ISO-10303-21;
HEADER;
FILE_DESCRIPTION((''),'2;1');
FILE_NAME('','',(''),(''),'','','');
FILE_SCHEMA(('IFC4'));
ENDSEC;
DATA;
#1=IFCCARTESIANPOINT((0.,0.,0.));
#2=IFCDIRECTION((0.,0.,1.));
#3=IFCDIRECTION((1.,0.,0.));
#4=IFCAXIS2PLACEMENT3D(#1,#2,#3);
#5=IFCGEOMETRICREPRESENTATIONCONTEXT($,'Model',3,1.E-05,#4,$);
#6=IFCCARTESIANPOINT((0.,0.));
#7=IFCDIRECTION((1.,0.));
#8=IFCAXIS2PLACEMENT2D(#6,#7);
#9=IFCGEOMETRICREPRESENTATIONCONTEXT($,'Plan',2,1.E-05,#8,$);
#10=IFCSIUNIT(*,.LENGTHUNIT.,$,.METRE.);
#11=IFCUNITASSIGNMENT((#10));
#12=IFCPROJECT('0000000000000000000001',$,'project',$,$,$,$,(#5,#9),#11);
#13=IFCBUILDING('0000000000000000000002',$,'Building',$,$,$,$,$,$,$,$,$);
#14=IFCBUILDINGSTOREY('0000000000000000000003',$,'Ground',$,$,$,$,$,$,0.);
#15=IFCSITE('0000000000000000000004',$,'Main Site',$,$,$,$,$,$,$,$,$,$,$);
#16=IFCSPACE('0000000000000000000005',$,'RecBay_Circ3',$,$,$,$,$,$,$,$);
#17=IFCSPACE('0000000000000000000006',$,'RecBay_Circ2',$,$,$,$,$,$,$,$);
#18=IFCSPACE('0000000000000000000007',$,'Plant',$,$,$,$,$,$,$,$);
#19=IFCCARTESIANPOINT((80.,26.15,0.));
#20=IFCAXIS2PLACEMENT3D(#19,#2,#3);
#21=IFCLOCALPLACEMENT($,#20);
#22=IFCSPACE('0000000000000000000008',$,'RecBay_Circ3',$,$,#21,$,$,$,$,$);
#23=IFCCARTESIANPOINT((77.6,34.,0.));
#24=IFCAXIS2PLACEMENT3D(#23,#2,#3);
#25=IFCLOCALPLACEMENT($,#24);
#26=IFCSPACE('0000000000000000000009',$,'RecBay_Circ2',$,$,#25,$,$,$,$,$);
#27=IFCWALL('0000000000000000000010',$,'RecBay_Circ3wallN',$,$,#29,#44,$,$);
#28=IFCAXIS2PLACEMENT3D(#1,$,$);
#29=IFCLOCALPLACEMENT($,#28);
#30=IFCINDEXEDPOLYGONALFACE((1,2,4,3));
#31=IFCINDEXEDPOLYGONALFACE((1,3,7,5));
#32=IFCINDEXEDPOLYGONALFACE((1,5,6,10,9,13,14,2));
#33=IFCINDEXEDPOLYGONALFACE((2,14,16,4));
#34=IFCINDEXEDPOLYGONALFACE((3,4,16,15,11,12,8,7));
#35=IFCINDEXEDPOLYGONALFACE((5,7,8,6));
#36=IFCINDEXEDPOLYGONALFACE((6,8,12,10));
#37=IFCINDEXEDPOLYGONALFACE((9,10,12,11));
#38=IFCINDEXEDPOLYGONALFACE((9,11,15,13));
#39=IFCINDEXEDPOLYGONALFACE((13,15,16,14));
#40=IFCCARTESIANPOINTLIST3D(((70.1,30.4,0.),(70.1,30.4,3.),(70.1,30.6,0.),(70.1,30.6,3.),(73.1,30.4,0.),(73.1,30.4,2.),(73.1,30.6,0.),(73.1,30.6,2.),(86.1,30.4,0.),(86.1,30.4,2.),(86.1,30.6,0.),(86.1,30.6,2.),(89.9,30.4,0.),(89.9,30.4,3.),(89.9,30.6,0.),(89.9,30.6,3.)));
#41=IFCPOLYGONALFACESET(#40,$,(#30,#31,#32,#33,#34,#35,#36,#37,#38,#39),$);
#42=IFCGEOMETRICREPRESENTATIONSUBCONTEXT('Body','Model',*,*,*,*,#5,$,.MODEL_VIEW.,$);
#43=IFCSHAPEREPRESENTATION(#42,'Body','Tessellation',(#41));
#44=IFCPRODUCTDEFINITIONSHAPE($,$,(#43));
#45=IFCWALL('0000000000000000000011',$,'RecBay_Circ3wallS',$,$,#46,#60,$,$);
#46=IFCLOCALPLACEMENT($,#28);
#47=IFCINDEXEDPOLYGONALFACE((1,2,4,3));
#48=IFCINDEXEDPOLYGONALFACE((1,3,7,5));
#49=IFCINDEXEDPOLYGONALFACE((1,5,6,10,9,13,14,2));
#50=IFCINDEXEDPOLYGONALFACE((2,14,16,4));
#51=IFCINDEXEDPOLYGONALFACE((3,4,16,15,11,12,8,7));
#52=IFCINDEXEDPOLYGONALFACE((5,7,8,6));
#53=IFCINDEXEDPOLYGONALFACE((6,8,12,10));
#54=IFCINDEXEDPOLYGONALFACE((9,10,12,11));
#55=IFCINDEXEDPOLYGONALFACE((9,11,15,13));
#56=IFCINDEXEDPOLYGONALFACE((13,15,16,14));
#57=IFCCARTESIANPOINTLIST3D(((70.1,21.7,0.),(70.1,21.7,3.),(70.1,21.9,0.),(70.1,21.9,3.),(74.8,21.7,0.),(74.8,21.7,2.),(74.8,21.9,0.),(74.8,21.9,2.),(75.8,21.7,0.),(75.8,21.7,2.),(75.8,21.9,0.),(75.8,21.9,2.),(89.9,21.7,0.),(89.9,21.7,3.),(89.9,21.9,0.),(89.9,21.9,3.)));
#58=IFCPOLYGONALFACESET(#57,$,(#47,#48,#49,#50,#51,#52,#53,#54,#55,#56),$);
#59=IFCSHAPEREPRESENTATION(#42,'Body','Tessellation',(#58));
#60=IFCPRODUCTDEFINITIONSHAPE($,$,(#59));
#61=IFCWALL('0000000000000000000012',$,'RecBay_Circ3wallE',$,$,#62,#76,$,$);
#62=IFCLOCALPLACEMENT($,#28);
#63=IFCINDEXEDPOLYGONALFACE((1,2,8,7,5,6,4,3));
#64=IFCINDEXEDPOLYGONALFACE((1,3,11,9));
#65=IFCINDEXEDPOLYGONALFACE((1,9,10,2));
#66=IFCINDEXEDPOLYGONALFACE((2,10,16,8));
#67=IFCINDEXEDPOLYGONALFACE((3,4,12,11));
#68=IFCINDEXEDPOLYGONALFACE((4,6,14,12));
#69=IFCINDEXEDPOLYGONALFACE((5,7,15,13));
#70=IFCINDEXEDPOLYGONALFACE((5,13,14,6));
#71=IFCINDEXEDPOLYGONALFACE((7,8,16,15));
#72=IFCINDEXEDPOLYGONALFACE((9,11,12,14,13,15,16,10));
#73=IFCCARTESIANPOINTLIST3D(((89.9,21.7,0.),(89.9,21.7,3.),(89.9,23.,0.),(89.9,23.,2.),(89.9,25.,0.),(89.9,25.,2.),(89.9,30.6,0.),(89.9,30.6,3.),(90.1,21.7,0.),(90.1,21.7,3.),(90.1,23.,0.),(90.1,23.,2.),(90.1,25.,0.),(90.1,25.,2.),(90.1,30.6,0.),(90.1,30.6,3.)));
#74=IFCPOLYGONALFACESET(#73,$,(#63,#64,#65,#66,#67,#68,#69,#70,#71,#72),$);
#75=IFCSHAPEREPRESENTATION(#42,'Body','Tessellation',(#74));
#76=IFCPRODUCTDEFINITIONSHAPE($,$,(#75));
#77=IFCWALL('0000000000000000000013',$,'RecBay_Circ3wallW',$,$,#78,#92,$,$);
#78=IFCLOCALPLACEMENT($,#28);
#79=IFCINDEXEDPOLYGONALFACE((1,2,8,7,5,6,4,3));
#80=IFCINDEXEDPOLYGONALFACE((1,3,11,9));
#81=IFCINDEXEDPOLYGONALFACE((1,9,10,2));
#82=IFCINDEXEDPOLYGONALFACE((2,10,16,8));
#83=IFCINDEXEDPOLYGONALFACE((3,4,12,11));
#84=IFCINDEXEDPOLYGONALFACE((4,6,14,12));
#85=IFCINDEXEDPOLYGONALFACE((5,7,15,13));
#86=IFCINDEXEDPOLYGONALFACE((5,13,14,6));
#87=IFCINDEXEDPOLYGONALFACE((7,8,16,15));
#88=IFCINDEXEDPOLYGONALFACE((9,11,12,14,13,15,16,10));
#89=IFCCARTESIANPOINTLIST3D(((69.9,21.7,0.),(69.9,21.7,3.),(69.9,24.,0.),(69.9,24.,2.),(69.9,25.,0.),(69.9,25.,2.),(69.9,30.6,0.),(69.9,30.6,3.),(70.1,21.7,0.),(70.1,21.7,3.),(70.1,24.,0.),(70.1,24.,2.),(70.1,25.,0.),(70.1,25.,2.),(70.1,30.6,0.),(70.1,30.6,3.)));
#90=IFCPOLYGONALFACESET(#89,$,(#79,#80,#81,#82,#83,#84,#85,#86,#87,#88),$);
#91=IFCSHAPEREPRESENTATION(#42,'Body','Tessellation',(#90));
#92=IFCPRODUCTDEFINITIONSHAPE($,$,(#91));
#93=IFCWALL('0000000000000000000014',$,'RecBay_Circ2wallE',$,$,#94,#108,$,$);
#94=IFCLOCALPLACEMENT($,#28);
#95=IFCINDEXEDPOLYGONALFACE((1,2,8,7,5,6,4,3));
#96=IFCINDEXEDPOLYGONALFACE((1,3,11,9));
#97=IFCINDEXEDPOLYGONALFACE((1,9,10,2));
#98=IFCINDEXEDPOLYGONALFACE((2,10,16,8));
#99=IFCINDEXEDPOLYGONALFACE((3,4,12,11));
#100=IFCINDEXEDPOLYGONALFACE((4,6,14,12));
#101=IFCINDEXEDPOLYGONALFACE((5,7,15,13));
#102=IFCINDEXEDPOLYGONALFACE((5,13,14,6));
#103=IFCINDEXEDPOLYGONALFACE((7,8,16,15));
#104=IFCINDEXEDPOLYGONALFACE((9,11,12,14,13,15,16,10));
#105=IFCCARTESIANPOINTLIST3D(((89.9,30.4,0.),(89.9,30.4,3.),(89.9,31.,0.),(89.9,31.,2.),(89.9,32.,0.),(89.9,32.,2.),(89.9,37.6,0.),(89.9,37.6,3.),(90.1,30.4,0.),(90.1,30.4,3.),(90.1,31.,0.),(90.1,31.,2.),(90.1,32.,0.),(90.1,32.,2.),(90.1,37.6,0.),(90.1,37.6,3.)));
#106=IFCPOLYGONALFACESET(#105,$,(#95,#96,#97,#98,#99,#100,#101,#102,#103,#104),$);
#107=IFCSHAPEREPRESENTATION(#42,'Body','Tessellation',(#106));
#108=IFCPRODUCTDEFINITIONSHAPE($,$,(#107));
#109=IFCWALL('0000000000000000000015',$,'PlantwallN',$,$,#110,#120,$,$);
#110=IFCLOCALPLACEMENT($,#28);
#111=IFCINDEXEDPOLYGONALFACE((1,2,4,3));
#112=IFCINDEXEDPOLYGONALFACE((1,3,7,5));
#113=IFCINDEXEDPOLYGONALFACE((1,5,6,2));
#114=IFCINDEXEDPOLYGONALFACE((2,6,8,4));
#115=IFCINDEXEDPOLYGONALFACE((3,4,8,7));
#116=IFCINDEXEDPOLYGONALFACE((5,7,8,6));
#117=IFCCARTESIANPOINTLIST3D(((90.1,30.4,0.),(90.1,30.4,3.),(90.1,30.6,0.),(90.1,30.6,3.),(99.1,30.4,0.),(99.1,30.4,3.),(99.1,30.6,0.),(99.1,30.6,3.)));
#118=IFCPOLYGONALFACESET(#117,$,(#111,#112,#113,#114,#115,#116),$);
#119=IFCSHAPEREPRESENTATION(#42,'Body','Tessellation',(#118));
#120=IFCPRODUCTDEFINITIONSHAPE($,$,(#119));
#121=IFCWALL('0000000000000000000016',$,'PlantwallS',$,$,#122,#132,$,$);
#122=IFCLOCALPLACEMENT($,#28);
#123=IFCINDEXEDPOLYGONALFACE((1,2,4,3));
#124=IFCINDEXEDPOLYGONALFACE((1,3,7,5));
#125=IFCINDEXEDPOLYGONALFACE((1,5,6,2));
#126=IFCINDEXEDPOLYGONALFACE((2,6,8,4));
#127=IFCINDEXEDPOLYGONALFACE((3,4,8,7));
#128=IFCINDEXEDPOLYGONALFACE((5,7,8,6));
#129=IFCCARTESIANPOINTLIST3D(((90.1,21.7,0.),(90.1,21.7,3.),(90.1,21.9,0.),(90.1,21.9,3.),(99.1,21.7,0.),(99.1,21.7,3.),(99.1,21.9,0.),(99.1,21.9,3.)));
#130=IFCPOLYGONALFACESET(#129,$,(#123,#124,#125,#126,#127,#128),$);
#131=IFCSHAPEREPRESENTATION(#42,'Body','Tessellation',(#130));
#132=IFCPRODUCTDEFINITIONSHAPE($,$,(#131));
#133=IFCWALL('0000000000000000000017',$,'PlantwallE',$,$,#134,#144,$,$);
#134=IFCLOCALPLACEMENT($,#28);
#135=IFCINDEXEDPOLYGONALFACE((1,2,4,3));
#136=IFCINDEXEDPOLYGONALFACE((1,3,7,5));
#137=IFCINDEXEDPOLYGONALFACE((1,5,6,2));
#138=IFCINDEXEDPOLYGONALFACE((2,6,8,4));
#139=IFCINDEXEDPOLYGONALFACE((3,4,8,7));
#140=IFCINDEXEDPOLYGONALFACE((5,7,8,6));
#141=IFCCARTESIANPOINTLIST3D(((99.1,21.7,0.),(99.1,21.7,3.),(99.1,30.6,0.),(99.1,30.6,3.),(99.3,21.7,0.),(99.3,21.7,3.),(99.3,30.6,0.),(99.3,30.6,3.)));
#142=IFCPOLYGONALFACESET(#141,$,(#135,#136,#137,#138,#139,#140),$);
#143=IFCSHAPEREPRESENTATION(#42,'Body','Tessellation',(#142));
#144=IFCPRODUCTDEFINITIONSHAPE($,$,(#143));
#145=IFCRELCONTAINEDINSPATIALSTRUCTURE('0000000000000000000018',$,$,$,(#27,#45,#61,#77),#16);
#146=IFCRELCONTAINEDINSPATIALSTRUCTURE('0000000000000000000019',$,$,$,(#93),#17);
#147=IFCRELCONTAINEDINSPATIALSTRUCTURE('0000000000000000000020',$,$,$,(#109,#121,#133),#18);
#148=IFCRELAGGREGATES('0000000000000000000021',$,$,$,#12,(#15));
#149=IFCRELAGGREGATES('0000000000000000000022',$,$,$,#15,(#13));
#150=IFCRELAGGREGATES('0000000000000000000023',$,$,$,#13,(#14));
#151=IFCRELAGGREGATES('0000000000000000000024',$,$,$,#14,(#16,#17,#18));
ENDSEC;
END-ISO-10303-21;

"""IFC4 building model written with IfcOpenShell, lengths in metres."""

from ifc_helpers import new_model, si_unit, frame, origin_with_axes, origin_2d_with_axis, place, context, subcontext, project, spatial, indexed_curve, outline, extrude, element, save


model = new_model("IFC4")

# Units and contexts
model_context = context("Model", 3, precision=1e-05, world=origin_with_axes())
plan_context = context("Plan", 2, precision=1e-05, world=origin_2d_with_axis())
body_context = subcontext(model_context, "Body", "Model", "MODEL_VIEW")
ifc_project = project(units=[si_unit("LENGTHUNIT", "METRE")], contexts=[model_context, plan_context])

# Site, building, storey
site = spatial("IfcSite", under=ifc_project, Name="Main Site")
building = spatial("IfcBuilding", under=site, Name="Building")
storey = spatial("IfcBuildingStorey", under=building, Name="Ground", Elevation=0.0)

# Shared definitions
space_1 = spatial("IfcSpace", under=storey, Name="RecBay_Circ3")

# Shared definitions
space_2 = spatial("IfcSpace", under=storey, Name="RecBay_Circ2")

# Shared definitions
space_3 = spatial("IfcSpace", under=storey, Name="Plant")

# Wall
wall_1_placement = place(None, frame((70.1, 30.4, 0.0), z_axis=(0.0, 0.0, 1.0), x_axis=(1.0, 0.0, 0.0)))
wall_1 = element("IfcWall", 1, at=wall_1_placement, inside=space_1, Name="RecBay_Circ3wallN", context=body_context, shape_type="SweptSolid", body=[
    extrude(outline(indexed_curve([(0.0, 0.0), (0.0, 0.2), (19.8, 0.2), (19.8, 0.0), (0.0, 0.0)], self_intersect=False)), origin_with_axes(), (0.0, 0.0, 1.0), 3.0),
])

# Shared definitions
space_4_placement = place(None, frame((80.0, 26.15, 0.0), z_axis=(0.0, 0.0, 1.0), x_axis=(1.0, 0.0, 0.0)))
space_4 = spatial("IfcSpace", at=space_4_placement, Name="RecBay_Circ3")

# Opening
opening_1_placement = place(wall_1_placement, frame((3.0, 0.0, 0.0), z_axis=(0.0, 0.0, 1.0), x_axis=(1.0, 0.0, 0.0)))
element("IfcOpeningElement", 2, at=opening_1_placement, inside=space_4, cuts=wall_1, context=body_context, shape_type="SweptSolid", body=[
    extrude(outline(indexed_curve([(0.0, 0.0), (0.0, 0.4), (13.0, 0.4), (13.0, 0.0), (0.0, 0.0)], self_intersect=False)), origin_with_axes(), (0.0, 0.0, 1.0), 2.0),
])

# Walls, openings
wall_2_placement = place(None, frame((70.1, 21.7, 0.0), z_axis=(0.0, 0.0, 1.0), x_axis=(1.0, 0.0, 0.0)))
wall_2 = element("IfcWall", 3, at=wall_2_placement, inside=space_1, Name="RecBay_Circ3wallS", context=body_context, shape_type="SweptSolid", body=[
    extrude(outline(indexed_curve([(0.0, 0.0), (0.0, 0.2), (19.8, 0.2), (19.8, 0.0), (0.0, 0.0)], self_intersect=False)), origin_with_axes(), (0.0, 0.0, 1.0), 3.0),
])
opening_2_placement = place(wall_2_placement, frame((4.7, 0.0, 0.0), z_axis=(0.0, 0.0, 1.0), x_axis=(1.0, 0.0, 0.0)))
element("IfcOpeningElement", 4, at=opening_2_placement, inside=space_4, cuts=wall_2, context=body_context, shape_type="SweptSolid", body=[
    extrude(outline(indexed_curve([(0.0, 0.0), (0.0, 0.4), (1.0, 0.4), (1.0, 0.0), (0.0, 0.0)], self_intersect=False)), origin_with_axes(), (0.0, 0.0, 1.0), 2.0),
])
wall_3_placement = place(None, frame((90.1, 21.7, 0.0), z_axis=(0.0, 0.0, 1.0), x_axis=(0.0, 1.0, 0.0)))
wall_3 = element("IfcWall", 5, at=wall_3_placement, inside=space_1, Name="RecBay_Circ3wallE", context=body_context, shape_type="SweptSolid", body=[
    extrude(outline(indexed_curve([(0.0, 0.0), (0.0, 0.2), (8.9, 0.2), (8.9, 0.0), (0.0, 0.0)], self_intersect=False)), origin_with_axes(), (0.0, 0.0, 1.0), 3.0),
])
opening_3_placement = place(wall_3_placement, frame((1.3, 0.0, 0.0), z_axis=(0.0, 0.0, 1.0), x_axis=(1.0, 0.0, 0.0)))
element("IfcOpeningElement", 6, at=opening_3_placement, inside=space_4, cuts=wall_3, context=body_context, shape_type="SweptSolid", body=[
    extrude(outline(indexed_curve([(0.0, 0.0), (0.0, 0.4), (2.0, 0.4), (2.0, 0.0), (0.0, 0.0)], self_intersect=False)), origin_with_axes(), (0.0, 0.0, 1.0), 2.0),
])
wall_4_placement = place(None, frame((70.1, 21.7, 0.0), z_axis=(0.0, 0.0, 1.0), x_axis=(0.0, 1.0, 0.0)))
wall_4 = element("IfcWall", 7, at=wall_4_placement, inside=space_1, Name="RecBay_Circ3wallW", context=body_context, shape_type="SweptSolid", body=[
    extrude(outline(indexed_curve([(0.0, 0.0), (0.0, 0.2), (8.9, 0.2), (8.9, 0.0), (0.0, 0.0)], self_intersect=False)), origin_with_axes(), (0.0, 0.0, 1.0), 3.0),
])
opening_4_placement = place(wall_4_placement, frame((2.3, 0.0, 0.0), z_axis=(0.0, 0.0, 1.0), x_axis=(1.0, 0.0, 0.0)))
element("IfcOpeningElement", 8, at=opening_4_placement, inside=space_4, cuts=wall_4, context=body_context, shape_type="SweptSolid", body=[
    extrude(outline(indexed_curve([(0.0, 0.0), (0.0, 0.4), (1.0, 0.4), (1.0, 0.0), (0.0, 0.0)], self_intersect=False)), origin_with_axes(), (0.0, 0.0, 1.0), 2.0),
])

# Wall
wall_5_placement = place(None, frame((90.1, 30.4, 0.0), z_axis=(0.0, 0.0, 1.0), x_axis=(0.0, 1.0, 0.0)))
wall_5 = element("IfcWall", 9, at=wall_5_placement, inside=space_2, Name="RecBay_Circ2wallE", context=body_context, shape_type="SweptSolid", body=[
    extrude(outline(indexed_curve([(0.0, 0.0), (0.0, 0.2), (7.2, 0.2), (7.2, 0.0), (0.0, 0.0)], self_intersect=False)), origin_with_axes(), (0.0, 0.0, 1.0), 3.0),
])

# Shared definitions
space_5_placement = place(None, frame((77.6, 34.0, 0.0), z_axis=(0.0, 0.0, 1.0), x_axis=(1.0, 0.0, 0.0)))
space_5 = spatial("IfcSpace", at=space_5_placement, Name="RecBay_Circ2")

# Opening
opening_5_placement = place(wall_5_placement, frame((0.6, 0.0, 0.0), z_axis=(0.0, 0.0, 1.0), x_axis=(1.0, 0.0, 0.0)))
element("IfcOpeningElement", 10, at=opening_5_placement, inside=space_5, cuts=wall_5, context=body_context, shape_type="SweptSolid", body=[
    extrude(outline(indexed_curve([(0.0, 0.0), (0.0, 0.4), (1.0, 0.4), (1.0, 0.0), (0.0, 0.0)], self_intersect=False)), origin_with_axes(), (0.0, 0.0, 1.0), 2.0),
])

# Walls
for number, where, z_axis, x_axis, name in (
    (11, (90.1, 30.4, 0.0), (0.0, 0.0, 1.0), (1.0, 0.0, 0.0), "PlantwallN"),
    (12, (90.1, 21.7, 0.0), (0.0, 0.0, 1.0), (1.0, 0.0, 0.0), "PlantwallS"),
):
    element("IfcWall", number, at=place(None, frame(where, z_axis=z_axis, x_axis=x_axis)), inside=space_3, Name=name, context=body_context, shape_type="SweptSolid", body=[
        extrude(outline(indexed_curve([(0.0, 0.0), (0.0, 0.2), (9.0, 0.2), (9.0, 0.0), (0.0, 0.0)], self_intersect=False)), origin_with_axes(), (0.0, 0.0, 1.0), 3.0),
    ])
wall_6_placement = place(None, frame((99.3, 21.7, 0.0), z_axis=(0.0, 0.0, 1.0), x_axis=(0.0, 1.0, 0.0)))
element("IfcWall", 13, at=wall_6_placement, inside=space_3, Name="PlantwallE", context=body_context, shape_type="SweptSolid", body=[
    extrude(outline(indexed_curve([(0.0, 0.0), (0.0, 0.2), (8.9, 0.2), (8.9, 0.0), (0.0, 0.0)], self_intersect=False)), origin_with_axes(), (0.0, 0.0, 1.0), 3.0),
])

save(model, "model.ifc")
